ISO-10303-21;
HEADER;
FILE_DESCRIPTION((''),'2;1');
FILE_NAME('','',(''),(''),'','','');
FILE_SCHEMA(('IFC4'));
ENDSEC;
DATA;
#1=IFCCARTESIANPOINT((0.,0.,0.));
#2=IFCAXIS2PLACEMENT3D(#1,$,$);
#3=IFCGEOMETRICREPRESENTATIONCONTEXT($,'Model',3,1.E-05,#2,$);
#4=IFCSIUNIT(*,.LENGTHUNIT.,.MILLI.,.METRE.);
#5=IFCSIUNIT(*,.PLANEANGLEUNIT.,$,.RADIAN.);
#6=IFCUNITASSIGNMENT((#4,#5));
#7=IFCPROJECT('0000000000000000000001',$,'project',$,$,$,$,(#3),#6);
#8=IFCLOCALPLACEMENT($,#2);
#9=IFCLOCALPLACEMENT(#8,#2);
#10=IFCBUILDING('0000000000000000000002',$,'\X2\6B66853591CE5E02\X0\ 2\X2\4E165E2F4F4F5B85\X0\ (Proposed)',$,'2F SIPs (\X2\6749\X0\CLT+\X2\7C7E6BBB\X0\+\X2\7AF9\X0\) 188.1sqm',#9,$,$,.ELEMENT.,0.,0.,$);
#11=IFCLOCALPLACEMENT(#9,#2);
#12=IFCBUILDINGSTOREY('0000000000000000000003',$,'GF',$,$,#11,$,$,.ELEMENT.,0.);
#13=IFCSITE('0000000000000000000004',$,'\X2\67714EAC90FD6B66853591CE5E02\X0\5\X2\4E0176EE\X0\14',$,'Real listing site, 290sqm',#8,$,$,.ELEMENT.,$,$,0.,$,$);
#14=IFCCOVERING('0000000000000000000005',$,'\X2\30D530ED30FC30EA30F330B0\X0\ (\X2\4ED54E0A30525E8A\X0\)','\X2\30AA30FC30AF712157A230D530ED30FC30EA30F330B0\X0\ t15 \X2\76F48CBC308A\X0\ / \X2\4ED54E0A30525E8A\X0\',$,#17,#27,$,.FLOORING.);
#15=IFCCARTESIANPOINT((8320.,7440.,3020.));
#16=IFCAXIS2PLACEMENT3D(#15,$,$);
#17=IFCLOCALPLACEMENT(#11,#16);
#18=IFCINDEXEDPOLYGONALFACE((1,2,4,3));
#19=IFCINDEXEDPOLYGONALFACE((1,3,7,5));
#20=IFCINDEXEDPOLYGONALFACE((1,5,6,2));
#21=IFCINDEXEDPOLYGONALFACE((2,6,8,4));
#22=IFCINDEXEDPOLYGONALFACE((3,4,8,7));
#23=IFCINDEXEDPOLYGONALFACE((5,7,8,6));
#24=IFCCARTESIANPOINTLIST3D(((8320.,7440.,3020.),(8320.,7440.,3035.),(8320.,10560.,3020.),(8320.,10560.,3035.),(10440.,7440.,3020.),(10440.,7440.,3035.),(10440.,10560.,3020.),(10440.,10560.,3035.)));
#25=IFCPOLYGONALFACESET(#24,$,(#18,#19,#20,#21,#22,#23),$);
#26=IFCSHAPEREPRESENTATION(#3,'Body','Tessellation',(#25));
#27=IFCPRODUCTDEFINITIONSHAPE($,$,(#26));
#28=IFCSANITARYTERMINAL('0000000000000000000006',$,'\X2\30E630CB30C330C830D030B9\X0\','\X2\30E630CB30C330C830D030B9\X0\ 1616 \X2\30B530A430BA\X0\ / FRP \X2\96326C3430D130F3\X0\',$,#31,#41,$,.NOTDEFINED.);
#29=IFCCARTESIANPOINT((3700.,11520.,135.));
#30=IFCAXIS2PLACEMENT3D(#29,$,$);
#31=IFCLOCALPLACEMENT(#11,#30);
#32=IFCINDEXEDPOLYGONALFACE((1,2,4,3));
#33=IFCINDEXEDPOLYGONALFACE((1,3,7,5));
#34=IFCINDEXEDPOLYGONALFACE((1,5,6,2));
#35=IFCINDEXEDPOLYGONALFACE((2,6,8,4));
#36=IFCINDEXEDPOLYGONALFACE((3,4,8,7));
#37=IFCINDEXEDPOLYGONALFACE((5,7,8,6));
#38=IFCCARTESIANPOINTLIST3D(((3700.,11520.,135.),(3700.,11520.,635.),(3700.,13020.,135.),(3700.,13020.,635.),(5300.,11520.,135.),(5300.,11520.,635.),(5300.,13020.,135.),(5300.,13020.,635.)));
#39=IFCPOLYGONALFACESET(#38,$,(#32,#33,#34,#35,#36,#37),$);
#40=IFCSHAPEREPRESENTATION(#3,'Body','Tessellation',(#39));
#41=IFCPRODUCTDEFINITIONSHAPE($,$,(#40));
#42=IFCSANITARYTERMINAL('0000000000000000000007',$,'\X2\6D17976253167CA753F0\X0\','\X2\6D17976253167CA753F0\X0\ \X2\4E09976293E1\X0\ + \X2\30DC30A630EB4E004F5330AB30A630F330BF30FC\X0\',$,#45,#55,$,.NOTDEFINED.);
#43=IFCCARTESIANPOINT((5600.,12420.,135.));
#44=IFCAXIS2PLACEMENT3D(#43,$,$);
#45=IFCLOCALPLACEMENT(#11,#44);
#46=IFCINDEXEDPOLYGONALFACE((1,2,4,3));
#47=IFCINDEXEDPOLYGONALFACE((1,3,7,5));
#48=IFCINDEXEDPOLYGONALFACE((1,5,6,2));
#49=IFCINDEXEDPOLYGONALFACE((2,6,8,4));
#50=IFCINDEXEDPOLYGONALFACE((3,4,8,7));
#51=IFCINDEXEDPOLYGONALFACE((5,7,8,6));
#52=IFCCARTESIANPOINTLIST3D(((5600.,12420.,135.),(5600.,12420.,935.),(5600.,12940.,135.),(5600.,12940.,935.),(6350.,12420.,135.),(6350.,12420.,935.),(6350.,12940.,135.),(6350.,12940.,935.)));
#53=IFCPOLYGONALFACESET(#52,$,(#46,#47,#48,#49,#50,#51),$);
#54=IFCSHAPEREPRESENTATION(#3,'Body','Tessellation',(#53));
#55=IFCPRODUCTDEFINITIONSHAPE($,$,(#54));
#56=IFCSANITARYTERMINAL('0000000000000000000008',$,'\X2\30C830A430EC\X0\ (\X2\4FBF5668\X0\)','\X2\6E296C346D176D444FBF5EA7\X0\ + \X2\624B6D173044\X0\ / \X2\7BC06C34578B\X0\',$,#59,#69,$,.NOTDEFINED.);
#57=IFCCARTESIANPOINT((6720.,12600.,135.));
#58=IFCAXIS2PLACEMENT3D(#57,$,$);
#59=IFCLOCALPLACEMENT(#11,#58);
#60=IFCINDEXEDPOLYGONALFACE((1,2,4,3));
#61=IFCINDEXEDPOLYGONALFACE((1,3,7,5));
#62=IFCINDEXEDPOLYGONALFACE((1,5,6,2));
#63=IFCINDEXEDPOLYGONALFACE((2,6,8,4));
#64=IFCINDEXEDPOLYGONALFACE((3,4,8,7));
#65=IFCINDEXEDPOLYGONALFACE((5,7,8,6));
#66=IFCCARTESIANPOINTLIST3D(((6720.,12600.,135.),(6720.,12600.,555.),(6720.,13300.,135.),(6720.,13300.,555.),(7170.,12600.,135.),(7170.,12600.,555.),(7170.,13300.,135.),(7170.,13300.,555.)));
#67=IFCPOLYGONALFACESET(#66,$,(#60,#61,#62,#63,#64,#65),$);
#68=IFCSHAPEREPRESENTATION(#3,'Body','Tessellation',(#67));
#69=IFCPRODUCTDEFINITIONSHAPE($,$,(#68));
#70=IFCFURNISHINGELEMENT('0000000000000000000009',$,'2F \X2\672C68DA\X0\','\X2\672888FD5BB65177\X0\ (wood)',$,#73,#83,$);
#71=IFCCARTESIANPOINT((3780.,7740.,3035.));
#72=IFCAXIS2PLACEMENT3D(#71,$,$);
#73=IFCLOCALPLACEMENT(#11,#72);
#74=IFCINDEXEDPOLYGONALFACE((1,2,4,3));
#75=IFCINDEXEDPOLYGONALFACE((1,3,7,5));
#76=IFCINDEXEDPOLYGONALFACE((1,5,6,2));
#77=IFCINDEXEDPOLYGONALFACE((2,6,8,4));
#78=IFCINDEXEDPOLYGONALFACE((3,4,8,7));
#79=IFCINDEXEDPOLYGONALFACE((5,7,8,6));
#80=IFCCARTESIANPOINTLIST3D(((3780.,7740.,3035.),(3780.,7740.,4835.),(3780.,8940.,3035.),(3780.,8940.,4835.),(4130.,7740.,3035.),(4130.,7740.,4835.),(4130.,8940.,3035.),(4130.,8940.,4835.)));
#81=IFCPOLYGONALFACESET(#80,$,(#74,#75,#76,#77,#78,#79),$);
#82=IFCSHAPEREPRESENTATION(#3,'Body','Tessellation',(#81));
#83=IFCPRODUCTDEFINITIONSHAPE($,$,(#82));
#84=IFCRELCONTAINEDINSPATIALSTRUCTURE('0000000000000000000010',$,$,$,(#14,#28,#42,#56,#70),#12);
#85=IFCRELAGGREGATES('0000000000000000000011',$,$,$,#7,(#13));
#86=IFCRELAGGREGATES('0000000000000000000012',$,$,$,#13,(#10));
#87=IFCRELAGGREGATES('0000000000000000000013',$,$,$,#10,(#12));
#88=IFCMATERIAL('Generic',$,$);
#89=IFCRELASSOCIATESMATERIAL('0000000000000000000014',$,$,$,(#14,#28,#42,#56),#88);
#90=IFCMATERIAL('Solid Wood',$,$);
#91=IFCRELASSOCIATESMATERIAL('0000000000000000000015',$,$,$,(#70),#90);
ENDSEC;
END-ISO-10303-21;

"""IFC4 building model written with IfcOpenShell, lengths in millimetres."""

from ifc_helpers import new_model, si_unit, frame, frame_2d, origin, place, context, project, spatial, rectangle, extrude, material, element, save


model = new_model("IFC4")

# Units and contexts
model_context = context("Model", 3, precision=1e-05, world=origin())
ifc_project = project(units=[si_unit("LENGTHUNIT", "METRE", prefix="MILLI"), si_unit("PLANEANGLEUNIT", "RADIAN")], contexts=[model_context])

# Site, building, storey
site_placement = place(None, origin())
site = spatial("IfcSite", under=ifc_project, at=site_placement, Name="東京都武蔵野市5丁目14", ObjectType="Real listing site, 290sqm", CompositionType="ELEMENT", RefElevation=0.0)
building_placement = place(site_placement, origin())
building = spatial("IfcBuilding", under=site, at=building_placement, Name="武蔵野市 2世帯住宅 (Proposed)", ObjectType="2F SIPs (杉CLT+籾殻+竹) 188.1sqm", CompositionType="ELEMENT", ElevationOfRefHeight=0.0, ElevationOfTerrain=0.0)
storey_placement = place(building_placement, origin())
storey = spatial("IfcBuildingStorey", under=building, at=storey_placement, Name="GF", CompositionType="ELEMENT", Elevation=0.0)

# Shared definitions
ifc_material_1 = material(Name="Solid Wood")
ifc_material_2 = material(Name="Generic")

# Covering
covering_1_placement = place(storey_placement, frame((8320.0, 7440.0, 3020.0)))
element("IfcCovering", 1, at=covering_1_placement, inside=storey, material=ifc_material_2, Name="フローリング (仕上げ床)", Description="オーク無垢フローリング t15 直貼り / 仕上げ床", PredefinedType="FLOORING", context=model_context, shape_type="SweptSolid", body=[
    extrude(rectangle(XDim=2120.0, YDim=3120.0, at=frame_2d((1060.0, 1560.0))), frame((8320.0, 7440.0, 3020.0)), (0.0, 0.0, 1.0), 15.0),
])

# Sanitary terminals
sanitary_terminal_1_placement = place(storey_placement, frame((3700.0, 11520.0, 135.0)))
element("IfcSanitaryTerminal", 2, at=sanitary_terminal_1_placement, inside=storey, material=ifc_material_2, Name="ユニットバス", Description="ユニットバス 1616 サイズ / FRP 防水パン", PredefinedType="NOTDEFINED", context=model_context, shape_type="SweptSolid", body=[
    extrude(rectangle(XDim=1600.0, YDim=1500.0, at=frame_2d((800.0, 750.0))), frame((3700.0, 11520.0, 135.0)), (0.0, 0.0, 1.0), 500.0),
])
sanitary_terminal_2_placement = place(storey_placement, frame((5600.0, 12420.0, 135.0)))
element("IfcSanitaryTerminal", 3, at=sanitary_terminal_2_placement, inside=storey, material=ifc_material_2, Name="洗面化粧台", Description="洗面化粧台 三面鏡 + ボウル一体カウンター", PredefinedType="NOTDEFINED", context=model_context, shape_type="SweptSolid", body=[
    extrude(rectangle(XDim=750.0, YDim=520.0, at=frame_2d((375.0, 260.0))), frame((5600.0, 12420.0, 135.0)), (0.0, 0.0, 1.0), 800.0),
])
sanitary_terminal_3_placement = place(storey_placement, frame((6720.0, 12600.0, 135.0)))
element("IfcSanitaryTerminal", 4, at=sanitary_terminal_3_placement, inside=storey, material=ifc_material_2, Name="トイレ (便器)", Description="温水洗浄便座 + 手洗い / 節水型", PredefinedType="NOTDEFINED", context=model_context, shape_type="SweptSolid", body=[
    extrude(rectangle(XDim=450.0, YDim=700.0, at=frame_2d((225.0, 350.0))), frame((6720.0, 12600.0, 135.0)), (0.0, 0.0, 1.0), 420.0),
])

# Furnishing element
furnishing_placement = place(storey_placement, frame((3780.0, 7740.0, 3035.0)))
element("IfcFurnishingElement", 5, at=furnishing_placement, inside=storey, material=ifc_material_1, Name="2F 本棚", Description="木製家具 (wood)", context=model_context, shape_type="SweptSolid", body=[
    extrude(rectangle(XDim=350.0, YDim=1200.0, at=frame_2d((175.0, 600.0))), frame((3780.0, 7740.0, 3035.0)), (0.0, 0.0, 1.0), 1800.0),
])

save(model, "model.ifc")
